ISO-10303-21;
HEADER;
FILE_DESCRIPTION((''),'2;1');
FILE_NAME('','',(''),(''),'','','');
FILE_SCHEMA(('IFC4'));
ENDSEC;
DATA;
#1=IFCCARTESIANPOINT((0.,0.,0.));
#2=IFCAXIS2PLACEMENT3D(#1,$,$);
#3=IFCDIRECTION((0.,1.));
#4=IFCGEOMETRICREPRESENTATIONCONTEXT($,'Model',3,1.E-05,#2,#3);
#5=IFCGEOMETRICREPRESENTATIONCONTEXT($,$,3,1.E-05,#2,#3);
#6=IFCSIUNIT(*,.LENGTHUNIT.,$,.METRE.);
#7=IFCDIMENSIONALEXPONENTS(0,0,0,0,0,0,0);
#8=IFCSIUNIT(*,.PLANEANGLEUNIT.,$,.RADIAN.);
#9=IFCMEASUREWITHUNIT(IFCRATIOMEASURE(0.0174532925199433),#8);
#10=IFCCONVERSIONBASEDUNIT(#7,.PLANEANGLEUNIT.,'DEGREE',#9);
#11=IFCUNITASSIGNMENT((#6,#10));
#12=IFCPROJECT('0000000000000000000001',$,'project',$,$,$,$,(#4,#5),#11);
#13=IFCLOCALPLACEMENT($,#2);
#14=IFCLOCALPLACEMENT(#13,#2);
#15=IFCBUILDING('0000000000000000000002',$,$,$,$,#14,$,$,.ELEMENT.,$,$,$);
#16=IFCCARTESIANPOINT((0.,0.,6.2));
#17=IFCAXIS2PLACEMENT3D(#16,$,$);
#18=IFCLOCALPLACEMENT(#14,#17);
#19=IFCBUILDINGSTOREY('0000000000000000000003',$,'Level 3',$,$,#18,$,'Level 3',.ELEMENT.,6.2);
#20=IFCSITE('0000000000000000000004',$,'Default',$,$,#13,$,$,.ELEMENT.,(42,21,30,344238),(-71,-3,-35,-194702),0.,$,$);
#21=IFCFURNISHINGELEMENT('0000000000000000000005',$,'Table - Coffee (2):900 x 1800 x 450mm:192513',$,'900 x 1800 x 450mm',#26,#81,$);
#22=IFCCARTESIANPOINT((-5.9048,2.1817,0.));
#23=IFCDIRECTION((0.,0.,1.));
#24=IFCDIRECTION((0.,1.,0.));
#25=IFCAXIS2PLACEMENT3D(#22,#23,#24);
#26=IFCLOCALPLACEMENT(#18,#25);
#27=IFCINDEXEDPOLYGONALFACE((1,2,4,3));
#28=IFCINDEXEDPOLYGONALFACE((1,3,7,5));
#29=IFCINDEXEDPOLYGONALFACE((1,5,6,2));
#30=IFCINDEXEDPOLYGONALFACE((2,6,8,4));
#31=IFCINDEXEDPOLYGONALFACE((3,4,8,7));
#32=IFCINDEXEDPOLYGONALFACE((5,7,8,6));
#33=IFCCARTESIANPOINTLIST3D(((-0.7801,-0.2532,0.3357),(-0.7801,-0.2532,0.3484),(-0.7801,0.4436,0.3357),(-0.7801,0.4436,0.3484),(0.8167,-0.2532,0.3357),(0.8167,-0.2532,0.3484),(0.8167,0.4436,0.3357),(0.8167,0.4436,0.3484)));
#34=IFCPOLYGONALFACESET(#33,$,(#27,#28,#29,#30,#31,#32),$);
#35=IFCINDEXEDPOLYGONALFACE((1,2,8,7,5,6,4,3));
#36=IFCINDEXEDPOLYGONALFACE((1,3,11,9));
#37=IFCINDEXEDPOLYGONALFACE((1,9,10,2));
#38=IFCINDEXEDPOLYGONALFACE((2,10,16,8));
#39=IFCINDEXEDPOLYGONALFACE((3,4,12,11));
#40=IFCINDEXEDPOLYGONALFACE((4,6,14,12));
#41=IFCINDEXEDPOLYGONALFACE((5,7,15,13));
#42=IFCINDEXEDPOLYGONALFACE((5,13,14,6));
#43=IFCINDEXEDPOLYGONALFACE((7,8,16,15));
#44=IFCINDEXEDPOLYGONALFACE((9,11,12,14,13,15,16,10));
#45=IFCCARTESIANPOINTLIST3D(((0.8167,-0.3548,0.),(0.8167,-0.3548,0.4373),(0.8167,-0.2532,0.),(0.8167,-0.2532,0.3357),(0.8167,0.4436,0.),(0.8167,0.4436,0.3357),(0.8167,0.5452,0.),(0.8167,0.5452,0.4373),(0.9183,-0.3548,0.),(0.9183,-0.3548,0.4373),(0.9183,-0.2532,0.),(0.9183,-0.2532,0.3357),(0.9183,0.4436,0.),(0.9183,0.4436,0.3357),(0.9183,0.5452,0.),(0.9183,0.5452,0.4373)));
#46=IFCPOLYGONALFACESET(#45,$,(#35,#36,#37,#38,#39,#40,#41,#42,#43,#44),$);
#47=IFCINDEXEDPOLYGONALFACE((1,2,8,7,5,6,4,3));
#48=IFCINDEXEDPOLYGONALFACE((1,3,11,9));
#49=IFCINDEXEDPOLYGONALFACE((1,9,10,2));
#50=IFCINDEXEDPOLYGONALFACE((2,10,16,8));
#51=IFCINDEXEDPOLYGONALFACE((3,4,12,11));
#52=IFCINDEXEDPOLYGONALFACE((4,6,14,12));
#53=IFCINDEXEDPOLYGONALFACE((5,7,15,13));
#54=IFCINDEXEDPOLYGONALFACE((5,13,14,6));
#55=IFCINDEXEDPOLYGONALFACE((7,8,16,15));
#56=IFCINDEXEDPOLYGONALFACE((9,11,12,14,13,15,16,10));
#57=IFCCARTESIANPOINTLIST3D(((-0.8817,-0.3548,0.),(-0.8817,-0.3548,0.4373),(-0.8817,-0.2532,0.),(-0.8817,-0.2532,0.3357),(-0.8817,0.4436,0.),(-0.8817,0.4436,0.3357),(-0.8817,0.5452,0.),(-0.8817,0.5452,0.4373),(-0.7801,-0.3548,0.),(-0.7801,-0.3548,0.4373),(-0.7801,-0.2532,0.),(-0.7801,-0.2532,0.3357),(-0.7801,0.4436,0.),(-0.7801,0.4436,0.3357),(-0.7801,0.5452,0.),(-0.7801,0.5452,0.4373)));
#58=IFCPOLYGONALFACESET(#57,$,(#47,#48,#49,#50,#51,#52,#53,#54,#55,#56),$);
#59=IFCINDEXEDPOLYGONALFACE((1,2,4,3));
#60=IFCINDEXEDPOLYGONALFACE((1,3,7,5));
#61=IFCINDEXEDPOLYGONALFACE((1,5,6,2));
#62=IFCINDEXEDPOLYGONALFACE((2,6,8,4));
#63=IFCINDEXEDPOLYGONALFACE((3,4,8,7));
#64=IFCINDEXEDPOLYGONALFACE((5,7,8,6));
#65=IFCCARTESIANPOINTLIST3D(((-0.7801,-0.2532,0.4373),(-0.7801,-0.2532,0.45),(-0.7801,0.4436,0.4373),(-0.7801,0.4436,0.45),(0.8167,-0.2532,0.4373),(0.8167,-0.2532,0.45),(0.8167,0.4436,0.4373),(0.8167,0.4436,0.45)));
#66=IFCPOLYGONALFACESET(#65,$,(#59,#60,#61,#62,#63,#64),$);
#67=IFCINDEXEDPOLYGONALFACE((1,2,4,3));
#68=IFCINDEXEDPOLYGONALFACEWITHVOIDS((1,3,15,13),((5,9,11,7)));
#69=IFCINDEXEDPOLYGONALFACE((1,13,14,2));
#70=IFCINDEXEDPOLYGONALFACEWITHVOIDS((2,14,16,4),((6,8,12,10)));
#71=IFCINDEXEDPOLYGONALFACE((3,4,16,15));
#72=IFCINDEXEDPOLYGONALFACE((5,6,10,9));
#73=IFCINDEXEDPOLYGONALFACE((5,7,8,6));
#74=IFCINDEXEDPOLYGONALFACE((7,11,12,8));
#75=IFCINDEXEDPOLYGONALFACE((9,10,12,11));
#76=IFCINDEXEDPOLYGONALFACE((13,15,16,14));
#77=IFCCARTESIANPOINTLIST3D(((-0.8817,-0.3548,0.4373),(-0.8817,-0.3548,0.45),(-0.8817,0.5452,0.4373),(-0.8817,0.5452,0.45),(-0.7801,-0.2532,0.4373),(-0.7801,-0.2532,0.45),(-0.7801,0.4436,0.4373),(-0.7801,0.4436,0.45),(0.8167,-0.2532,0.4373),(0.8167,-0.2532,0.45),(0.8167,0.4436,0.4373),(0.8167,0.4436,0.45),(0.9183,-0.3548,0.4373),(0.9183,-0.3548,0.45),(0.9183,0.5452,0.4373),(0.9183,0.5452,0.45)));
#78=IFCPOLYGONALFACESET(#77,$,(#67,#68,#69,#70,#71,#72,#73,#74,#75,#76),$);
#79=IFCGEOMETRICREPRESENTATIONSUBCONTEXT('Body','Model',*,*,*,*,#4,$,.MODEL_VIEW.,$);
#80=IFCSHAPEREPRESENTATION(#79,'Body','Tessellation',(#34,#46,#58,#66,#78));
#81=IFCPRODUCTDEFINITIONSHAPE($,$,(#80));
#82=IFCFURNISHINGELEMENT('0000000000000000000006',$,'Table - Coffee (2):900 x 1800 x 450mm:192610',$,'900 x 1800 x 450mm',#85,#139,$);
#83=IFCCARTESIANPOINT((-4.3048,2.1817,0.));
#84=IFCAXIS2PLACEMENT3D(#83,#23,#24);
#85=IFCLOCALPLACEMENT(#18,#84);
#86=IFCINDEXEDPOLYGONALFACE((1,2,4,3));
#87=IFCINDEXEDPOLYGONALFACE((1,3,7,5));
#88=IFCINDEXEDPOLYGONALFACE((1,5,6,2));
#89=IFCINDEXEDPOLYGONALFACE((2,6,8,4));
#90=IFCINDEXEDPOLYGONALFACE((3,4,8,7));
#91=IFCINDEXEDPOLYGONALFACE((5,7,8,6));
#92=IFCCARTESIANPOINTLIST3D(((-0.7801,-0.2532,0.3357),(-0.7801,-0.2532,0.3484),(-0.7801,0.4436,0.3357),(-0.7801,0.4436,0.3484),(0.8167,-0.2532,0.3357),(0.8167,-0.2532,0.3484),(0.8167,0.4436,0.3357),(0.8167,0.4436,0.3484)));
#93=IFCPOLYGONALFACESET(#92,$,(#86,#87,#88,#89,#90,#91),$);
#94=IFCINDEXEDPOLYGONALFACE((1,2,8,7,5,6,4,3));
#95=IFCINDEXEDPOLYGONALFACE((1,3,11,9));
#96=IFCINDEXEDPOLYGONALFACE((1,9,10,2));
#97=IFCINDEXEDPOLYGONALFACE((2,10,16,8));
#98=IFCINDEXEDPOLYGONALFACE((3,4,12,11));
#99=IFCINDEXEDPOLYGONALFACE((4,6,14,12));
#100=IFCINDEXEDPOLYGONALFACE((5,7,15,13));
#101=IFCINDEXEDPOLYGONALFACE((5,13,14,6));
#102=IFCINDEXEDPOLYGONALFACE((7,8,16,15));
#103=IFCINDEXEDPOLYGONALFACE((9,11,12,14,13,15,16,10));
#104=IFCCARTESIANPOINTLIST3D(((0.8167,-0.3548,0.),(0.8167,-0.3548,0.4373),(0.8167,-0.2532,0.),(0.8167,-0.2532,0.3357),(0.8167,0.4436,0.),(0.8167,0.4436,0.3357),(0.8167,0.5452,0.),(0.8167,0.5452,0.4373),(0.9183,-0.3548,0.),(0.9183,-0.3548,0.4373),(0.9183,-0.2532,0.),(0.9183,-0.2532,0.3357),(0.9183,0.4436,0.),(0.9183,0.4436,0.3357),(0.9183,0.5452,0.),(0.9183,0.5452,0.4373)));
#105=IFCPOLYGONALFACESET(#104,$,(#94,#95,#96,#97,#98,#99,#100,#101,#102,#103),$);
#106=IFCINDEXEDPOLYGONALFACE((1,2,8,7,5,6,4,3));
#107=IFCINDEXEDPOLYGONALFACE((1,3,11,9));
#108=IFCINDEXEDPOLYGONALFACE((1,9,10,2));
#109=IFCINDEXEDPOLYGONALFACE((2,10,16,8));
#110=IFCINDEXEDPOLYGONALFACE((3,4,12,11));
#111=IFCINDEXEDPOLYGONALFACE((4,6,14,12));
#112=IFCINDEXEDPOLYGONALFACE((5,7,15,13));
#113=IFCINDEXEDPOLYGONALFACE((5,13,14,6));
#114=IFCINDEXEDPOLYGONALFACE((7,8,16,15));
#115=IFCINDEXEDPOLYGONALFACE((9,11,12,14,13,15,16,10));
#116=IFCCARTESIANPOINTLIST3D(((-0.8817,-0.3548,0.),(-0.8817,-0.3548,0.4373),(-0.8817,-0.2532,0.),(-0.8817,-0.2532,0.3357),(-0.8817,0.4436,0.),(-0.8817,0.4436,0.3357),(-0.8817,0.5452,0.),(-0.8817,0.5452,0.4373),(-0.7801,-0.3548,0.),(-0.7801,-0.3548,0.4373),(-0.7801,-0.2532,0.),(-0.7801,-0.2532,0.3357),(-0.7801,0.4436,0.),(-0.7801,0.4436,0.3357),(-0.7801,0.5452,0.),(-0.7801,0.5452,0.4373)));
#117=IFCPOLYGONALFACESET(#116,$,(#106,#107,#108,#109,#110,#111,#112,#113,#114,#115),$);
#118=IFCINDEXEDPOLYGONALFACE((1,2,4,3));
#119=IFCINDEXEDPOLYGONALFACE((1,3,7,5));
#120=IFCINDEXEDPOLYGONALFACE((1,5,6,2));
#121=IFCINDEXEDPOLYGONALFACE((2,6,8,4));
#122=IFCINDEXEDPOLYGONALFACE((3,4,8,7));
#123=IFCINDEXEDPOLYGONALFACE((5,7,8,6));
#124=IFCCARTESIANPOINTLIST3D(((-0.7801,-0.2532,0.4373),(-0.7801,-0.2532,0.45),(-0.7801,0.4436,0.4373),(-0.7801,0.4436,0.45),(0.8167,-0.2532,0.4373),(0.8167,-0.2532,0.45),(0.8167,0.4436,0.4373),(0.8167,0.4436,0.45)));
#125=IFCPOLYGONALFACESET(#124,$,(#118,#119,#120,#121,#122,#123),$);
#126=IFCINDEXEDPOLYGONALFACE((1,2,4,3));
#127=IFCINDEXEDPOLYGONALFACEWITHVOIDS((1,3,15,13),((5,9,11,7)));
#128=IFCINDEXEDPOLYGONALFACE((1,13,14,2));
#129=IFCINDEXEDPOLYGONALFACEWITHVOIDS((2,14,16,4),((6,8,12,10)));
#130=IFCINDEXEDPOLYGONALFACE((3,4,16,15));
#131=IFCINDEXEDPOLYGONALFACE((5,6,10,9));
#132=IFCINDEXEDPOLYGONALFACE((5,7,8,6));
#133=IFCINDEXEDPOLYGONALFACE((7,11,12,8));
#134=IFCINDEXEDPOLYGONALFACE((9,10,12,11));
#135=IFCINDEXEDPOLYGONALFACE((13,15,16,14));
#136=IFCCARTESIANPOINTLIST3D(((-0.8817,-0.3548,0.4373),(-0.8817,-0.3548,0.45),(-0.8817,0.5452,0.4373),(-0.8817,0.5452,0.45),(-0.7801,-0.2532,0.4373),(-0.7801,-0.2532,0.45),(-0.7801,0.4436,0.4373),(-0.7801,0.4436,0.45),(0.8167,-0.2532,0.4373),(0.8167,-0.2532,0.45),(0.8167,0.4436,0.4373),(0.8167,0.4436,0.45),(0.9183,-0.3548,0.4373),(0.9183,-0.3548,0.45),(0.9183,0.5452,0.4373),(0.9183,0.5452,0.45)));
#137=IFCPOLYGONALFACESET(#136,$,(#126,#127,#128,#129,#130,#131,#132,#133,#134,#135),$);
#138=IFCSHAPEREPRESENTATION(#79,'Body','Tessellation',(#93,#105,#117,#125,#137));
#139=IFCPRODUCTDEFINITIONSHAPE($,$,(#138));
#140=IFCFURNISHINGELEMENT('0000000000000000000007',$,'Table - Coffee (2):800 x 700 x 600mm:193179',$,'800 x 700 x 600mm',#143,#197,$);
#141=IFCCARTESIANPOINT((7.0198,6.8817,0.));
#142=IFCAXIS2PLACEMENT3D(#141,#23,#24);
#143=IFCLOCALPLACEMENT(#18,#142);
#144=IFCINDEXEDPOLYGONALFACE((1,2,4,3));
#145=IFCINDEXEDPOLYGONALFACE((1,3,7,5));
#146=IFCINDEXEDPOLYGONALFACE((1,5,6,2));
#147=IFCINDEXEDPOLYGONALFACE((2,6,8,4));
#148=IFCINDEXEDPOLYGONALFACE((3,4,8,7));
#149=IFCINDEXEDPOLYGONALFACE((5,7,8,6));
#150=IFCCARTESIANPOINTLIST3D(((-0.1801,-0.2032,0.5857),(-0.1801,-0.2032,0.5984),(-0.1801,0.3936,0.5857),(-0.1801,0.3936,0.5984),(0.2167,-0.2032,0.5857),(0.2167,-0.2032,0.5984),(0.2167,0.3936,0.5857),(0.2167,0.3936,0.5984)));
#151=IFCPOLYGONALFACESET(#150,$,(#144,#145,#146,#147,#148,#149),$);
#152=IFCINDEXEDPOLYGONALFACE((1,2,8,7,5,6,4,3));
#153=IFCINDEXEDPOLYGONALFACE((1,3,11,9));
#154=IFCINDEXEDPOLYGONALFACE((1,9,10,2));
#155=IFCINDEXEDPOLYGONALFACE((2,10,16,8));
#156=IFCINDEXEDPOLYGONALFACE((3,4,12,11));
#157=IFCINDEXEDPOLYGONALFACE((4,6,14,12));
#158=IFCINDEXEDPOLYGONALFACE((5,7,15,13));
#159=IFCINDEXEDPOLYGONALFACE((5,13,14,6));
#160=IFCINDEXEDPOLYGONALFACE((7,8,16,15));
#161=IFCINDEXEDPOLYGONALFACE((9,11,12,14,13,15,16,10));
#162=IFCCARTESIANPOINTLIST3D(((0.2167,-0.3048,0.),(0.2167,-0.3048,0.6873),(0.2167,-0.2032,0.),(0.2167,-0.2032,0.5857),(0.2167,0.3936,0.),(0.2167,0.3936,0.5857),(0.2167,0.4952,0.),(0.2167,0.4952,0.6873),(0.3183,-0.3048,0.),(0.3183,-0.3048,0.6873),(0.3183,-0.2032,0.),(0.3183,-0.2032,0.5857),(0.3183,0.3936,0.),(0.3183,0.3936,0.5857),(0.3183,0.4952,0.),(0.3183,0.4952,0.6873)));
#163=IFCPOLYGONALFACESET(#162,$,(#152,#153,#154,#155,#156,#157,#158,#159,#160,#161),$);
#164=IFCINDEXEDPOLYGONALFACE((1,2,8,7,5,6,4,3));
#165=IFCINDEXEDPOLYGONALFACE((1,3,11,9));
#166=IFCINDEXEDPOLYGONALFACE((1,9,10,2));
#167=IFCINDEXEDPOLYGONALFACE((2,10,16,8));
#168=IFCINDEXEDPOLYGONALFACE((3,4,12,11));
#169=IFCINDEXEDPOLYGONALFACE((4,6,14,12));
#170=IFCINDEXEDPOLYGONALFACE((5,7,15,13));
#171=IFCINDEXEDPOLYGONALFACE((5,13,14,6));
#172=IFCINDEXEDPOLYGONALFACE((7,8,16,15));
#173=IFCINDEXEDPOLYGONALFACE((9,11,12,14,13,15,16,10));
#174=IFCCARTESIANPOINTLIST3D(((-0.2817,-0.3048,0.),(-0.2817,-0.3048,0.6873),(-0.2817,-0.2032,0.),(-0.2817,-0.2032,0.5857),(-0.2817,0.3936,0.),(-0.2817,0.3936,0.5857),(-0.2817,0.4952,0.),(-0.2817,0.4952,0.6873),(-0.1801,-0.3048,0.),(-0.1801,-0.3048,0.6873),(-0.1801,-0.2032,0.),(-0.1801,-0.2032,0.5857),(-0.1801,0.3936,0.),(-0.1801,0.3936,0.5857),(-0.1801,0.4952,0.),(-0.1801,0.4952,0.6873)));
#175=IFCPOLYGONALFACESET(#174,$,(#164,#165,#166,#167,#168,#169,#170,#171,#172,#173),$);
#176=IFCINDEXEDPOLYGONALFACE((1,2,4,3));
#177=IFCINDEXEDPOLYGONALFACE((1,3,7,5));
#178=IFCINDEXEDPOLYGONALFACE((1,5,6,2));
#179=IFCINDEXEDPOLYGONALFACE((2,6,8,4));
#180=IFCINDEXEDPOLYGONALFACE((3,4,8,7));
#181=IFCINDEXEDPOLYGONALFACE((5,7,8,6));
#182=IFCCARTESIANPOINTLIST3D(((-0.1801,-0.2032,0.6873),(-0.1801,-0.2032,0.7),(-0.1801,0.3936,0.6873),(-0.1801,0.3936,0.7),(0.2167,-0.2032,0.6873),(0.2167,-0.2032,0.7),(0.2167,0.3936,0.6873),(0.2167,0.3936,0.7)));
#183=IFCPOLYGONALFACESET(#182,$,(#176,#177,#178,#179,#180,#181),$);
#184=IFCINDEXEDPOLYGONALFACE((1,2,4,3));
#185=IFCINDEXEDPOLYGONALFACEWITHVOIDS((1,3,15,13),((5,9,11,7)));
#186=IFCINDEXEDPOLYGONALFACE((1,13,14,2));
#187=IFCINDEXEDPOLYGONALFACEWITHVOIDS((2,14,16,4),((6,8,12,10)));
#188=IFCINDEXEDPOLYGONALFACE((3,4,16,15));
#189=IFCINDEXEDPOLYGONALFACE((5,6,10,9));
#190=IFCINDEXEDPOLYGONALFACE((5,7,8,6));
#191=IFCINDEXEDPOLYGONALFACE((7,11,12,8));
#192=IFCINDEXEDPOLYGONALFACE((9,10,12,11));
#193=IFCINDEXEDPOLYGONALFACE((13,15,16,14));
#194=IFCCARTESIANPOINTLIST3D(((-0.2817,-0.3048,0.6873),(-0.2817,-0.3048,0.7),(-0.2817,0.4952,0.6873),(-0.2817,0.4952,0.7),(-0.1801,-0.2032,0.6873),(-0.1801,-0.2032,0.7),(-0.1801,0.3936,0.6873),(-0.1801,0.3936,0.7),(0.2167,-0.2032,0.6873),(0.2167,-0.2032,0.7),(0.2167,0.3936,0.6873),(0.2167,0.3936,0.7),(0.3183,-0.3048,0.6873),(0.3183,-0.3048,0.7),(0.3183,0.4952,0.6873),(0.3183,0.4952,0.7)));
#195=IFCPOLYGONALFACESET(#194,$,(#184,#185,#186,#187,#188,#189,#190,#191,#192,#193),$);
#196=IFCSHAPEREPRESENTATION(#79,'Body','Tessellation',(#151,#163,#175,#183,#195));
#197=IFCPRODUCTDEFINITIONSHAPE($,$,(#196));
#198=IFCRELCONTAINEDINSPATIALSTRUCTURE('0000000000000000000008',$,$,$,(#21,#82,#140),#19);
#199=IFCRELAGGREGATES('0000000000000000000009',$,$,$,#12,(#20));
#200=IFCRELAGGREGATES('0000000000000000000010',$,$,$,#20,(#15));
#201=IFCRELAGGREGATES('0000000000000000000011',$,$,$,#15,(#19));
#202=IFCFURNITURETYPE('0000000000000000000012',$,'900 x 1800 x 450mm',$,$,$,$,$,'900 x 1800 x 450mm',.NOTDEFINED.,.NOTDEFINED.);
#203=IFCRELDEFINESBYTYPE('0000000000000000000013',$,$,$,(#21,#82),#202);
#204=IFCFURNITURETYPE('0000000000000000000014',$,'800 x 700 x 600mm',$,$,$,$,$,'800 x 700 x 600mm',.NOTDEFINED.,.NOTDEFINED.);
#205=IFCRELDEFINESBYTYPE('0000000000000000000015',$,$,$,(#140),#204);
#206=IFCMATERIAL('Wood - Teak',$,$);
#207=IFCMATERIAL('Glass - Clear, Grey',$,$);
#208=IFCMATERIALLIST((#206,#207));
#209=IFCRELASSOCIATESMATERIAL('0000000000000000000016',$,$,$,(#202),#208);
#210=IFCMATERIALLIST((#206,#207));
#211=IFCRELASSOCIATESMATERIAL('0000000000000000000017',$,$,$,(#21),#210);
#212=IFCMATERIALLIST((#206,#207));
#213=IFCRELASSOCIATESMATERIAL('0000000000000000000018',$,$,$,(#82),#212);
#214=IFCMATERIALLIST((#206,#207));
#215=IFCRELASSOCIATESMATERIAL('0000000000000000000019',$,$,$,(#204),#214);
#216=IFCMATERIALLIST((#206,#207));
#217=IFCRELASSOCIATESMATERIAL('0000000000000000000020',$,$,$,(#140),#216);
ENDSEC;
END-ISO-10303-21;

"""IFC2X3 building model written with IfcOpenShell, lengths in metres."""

from ifc_helpers import new_model, entity, si_unit, converted_unit, direction, frame, frame_2d, origin, origin_2d_with_axis, place, context, subcontext, project, spatial, polyline, rectangle, outline, extrude, source, transform, mapped, material, material_list, type_object, type_shapes, element, save


model = new_model("IFC2X3")

# Units and contexts
model_context = context("Model", 3, precision=1e-05, world=origin(), true_north=direction((0.0, 1.0)))
context_of_model = context(None, 3, precision=1e-05, world=origin(), true_north=direction((0.0, 1.0)))
body_context = subcontext(model_context, "Body", "Model", "MODEL_VIEW")
ifc_project = project(units=[si_unit("LENGTHUNIT", "METRE"), converted_unit("PLANEANGLEUNIT", "DEGREE", entity("IfcRatioMeasure", 0.0174532925199433), si_unit("PLANEANGLEUNIT", "RADIAN"), dimensions=[0, 0, 0, 0, 0, 0, 0])], contexts=[model_context, context_of_model])

# Site, building, storey
site_placement = place(None, origin())
site = spatial("IfcSite", under=ifc_project, at=site_placement, Name="Default", CompositionType="ELEMENT", RefLatitude=(42, 21, 30, 344238), RefLongitude=(-71, -3, -35, -194702), RefElevation=0.0)
building_placement = place(site_placement, origin())
building = spatial("IfcBuilding", under=site, at=building_placement, CompositionType="ELEMENT")
storey_placement = place(building_placement, frame((0.0, 0.0, 6.2)))
storey = spatial("IfcBuildingStorey", under=building, at=storey_placement, Name="Level 3", LongName="Level 3", CompositionType="ELEMENT", Elevation=6.2)

# Furnishing elements
ifc_material_1 = material(Name="Wood - Teak")
ifc_material_2 = material(Name="Glass - Clear, Grey")
ifc_material_list_1 = material_list([ifc_material_1, ifc_material_2])
ifc_material_list_2 = material_list([ifc_material_1, ifc_material_2])
furniture_type_1 = type_object("IfcFurnitureType", Name="900 x 1800 x 450mm", ElementType="900 x 1800 x 450mm", AssemblyPlace="NOTDEFINED", material=ifc_material_list_2)
shared_shape_1 = source(origin(), body_context, "Body", "SweptSolid", [
    extrude(rectangle(XDim=1.5968, YDim=0.6968, at=origin_2d_with_axis()), frame((0.0183, 0.0952, 0.3357), z_axis=(0.0, 0.0, 1.0), x_axis=(-1.0, 0.0, 0.0)), (0.0, 0.0, 1.0), 0.0127),
    extrude(outline(polyline([(-0.1932, -0.45), (0.244, -0.45), (0.244, 0.45), (-0.1932, 0.45), (-0.1932, 0.3484), (0.1425, 0.3484), (0.1425, -0.3484), (-0.1932, -0.3484), (-0.1932, -0.45)])), frame((0.8167, 0.0952, 0.1932), z_axis=(1.0, 0.0, 0.0), x_axis=(0.0, 0.0, 1.0)), (0.0, 0.0, 1.0), 0.1016),
    extrude(outline(polyline([(-0.45, -0.2441), (0.45, -0.2441), (0.45, 0.1933), (0.3484, 0.1933), (0.3484, -0.1424), (-0.3484, -0.1424), (-0.3484, 0.1933), (-0.45, 0.1933), (-0.45, -0.2441)])), frame((-0.8817, 0.0952, 0.1933), z_axis=(1.0, 0.0, 0.0), x_axis=(0.0, -1.0, 0.0)), (0.0, 0.0, 1.0), 0.1016),
    extrude(rectangle(XDim=1.5968, YDim=0.6968, at=origin_2d_with_axis()), frame((0.0183, 0.0952, 0.4373), z_axis=(0.0, 0.0, 1.0), x_axis=(-1.0, 0.0, 0.0)), (0.0, 0.0, 1.0), 0.0127),
    extrude(outline(polyline([(-0.9, -0.45), (0.9, -0.45), (0.9, 0.45), (-0.9, 0.45), (-0.9, -0.45)]), holes=[polyline([(-0.7984, -0.3484), (-0.7984, 0.3484), (0.7984, 0.3484), (0.7984, -0.3484), (-0.7984, -0.3484)])]), frame((0.0183, 0.0952, 0.4373), z_axis=(0.0, 0.0, 1.0), x_axis=(-1.0, 0.0, 0.0)), (0.0, 0.0, 1.0), 0.0127),
])
type_shapes(furniture_type_1, [shared_shape_1])
furnishing_1_placement = place(storey_placement, frame((-5.9048, 2.1817, 0.0), z_axis=(0.0, 0.0, 1.0), x_axis=(0.0, 1.0, 0.0)))
element("IfcFurnishingElement", 1, at=furnishing_1_placement, inside=storey, type_object=furniture_type_1, material=ifc_material_list_1, Name="Table - Coffee (2):900 x 1800 x 450mm:192513", ObjectType="900 x 1800 x 450mm", context=body_context, shape_type="MappedRepresentation", body=[
    mapped(shared_shape_1, transform((0.0, 0.0, 0.0), scale=1.0)),
])
ifc_material_list_3 = material_list([ifc_material_1, ifc_material_2])
furnishing_2_placement = place(storey_placement, frame((-4.3048, 2.1817, 0.0), z_axis=(0.0, 0.0, 1.0), x_axis=(0.0, 1.0, 0.0)))
element("IfcFurnishingElement", 2, at=furnishing_2_placement, inside=storey, type_object=furniture_type_1, material=ifc_material_list_3, Name="Table - Coffee (2):900 x 1800 x 450mm:192610", ObjectType="900 x 1800 x 450mm", context=body_context, shape_type="MappedRepresentation", body=[
    mapped(shared_shape_1, transform((0.0, 0.0, 0.0), scale=1.0)),
])
ifc_material_list_4 = material_list([ifc_material_1, ifc_material_2])
ifc_material_list_5 = material_list([ifc_material_1, ifc_material_2])
furniture_type_2 = type_object("IfcFurnitureType", Name="800 x 700 x 600mm", ElementType="800 x 700 x 600mm", AssemblyPlace="NOTDEFINED", material=ifc_material_list_5)
shared_shape_2 = source(origin(), body_context, "Body", "SweptSolid", [
    extrude(rectangle(XDim=0.3968, YDim=0.5968, at=origin_2d_with_axis()), frame((0.0183, 0.0952, 0.5857), z_axis=(0.0, 0.0, 1.0), x_axis=(-1.0, 0.0, 0.0)), (0.0, 0.0, 1.0), 0.0127),
    extrude(outline(polyline([(-0.3182, -0.4), (0.369, -0.4), (0.369, 0.4), (-0.3182, 0.4), (-0.3182, 0.2984), (0.2675, 0.2984), (0.2675, -0.2984), (-0.3182, -0.2984), (-0.3182, -0.4)])), frame((0.2167, 0.0952, 0.3182), z_axis=(1.0, 0.0, 0.0), x_axis=(0.0, 0.0, 1.0)), (0.0, 0.0, 1.0), 0.1016),
    extrude(outline(polyline([(-0.4, -0.3691), (0.4, -0.3691), (0.4, 0.3183), (0.2984, 0.3183), (0.2984, -0.2674), (-0.2984, -0.2674), (-0.2984, 0.3183), (-0.4, 0.3183), (-0.4, -0.3691)])), frame((-0.2817, 0.0952, 0.3183), z_axis=(1.0, 0.0, 0.0), x_axis=(0.0, -1.0, 0.0)), (0.0, 0.0, 1.0), 0.1016),
    extrude(rectangle(XDim=0.3968, YDim=0.5968, at=frame_2d((0.0, 0.0), x_axis=(1.0, 0.0))), frame((0.0183, 0.0952, 0.6873), z_axis=(0.0, 0.0, 1.0), x_axis=(-1.0, 0.0, 0.0)), (0.0, 0.0, 1.0), 0.0127),
    extrude(outline(polyline([(-0.3, -0.4), (0.3, -0.4), (0.3, 0.4), (-0.3, 0.4), (-0.3, -0.4)]), holes=[polyline([(-0.1984, -0.2984), (-0.1984, 0.2984), (0.1984, 0.2984), (0.1984, -0.2984), (-0.1984, -0.2984)])]), frame((0.0183, 0.0952, 0.6873), z_axis=(0.0, 0.0, 1.0), x_axis=(-1.0, 0.0, 0.0)), (0.0, 0.0, 1.0), 0.0127),
])
type_shapes(furniture_type_2, [shared_shape_2])
furnishing_3_placement = place(storey_placement, frame((7.0198, 6.8817, 0.0), z_axis=(0.0, 0.0, 1.0), x_axis=(0.0, 1.0, 0.0)))
element("IfcFurnishingElement", 3, at=furnishing_3_placement, inside=storey, type_object=furniture_type_2, material=ifc_material_list_4, Name="Table - Coffee (2):800 x 700 x 600mm:193179", ObjectType="800 x 700 x 600mm", context=body_context, shape_type="MappedRepresentation", body=[
    mapped(shared_shape_2, transform((0.0, 0.0, 0.0), scale=1.0)),
])

save(model, "model.ifc")
